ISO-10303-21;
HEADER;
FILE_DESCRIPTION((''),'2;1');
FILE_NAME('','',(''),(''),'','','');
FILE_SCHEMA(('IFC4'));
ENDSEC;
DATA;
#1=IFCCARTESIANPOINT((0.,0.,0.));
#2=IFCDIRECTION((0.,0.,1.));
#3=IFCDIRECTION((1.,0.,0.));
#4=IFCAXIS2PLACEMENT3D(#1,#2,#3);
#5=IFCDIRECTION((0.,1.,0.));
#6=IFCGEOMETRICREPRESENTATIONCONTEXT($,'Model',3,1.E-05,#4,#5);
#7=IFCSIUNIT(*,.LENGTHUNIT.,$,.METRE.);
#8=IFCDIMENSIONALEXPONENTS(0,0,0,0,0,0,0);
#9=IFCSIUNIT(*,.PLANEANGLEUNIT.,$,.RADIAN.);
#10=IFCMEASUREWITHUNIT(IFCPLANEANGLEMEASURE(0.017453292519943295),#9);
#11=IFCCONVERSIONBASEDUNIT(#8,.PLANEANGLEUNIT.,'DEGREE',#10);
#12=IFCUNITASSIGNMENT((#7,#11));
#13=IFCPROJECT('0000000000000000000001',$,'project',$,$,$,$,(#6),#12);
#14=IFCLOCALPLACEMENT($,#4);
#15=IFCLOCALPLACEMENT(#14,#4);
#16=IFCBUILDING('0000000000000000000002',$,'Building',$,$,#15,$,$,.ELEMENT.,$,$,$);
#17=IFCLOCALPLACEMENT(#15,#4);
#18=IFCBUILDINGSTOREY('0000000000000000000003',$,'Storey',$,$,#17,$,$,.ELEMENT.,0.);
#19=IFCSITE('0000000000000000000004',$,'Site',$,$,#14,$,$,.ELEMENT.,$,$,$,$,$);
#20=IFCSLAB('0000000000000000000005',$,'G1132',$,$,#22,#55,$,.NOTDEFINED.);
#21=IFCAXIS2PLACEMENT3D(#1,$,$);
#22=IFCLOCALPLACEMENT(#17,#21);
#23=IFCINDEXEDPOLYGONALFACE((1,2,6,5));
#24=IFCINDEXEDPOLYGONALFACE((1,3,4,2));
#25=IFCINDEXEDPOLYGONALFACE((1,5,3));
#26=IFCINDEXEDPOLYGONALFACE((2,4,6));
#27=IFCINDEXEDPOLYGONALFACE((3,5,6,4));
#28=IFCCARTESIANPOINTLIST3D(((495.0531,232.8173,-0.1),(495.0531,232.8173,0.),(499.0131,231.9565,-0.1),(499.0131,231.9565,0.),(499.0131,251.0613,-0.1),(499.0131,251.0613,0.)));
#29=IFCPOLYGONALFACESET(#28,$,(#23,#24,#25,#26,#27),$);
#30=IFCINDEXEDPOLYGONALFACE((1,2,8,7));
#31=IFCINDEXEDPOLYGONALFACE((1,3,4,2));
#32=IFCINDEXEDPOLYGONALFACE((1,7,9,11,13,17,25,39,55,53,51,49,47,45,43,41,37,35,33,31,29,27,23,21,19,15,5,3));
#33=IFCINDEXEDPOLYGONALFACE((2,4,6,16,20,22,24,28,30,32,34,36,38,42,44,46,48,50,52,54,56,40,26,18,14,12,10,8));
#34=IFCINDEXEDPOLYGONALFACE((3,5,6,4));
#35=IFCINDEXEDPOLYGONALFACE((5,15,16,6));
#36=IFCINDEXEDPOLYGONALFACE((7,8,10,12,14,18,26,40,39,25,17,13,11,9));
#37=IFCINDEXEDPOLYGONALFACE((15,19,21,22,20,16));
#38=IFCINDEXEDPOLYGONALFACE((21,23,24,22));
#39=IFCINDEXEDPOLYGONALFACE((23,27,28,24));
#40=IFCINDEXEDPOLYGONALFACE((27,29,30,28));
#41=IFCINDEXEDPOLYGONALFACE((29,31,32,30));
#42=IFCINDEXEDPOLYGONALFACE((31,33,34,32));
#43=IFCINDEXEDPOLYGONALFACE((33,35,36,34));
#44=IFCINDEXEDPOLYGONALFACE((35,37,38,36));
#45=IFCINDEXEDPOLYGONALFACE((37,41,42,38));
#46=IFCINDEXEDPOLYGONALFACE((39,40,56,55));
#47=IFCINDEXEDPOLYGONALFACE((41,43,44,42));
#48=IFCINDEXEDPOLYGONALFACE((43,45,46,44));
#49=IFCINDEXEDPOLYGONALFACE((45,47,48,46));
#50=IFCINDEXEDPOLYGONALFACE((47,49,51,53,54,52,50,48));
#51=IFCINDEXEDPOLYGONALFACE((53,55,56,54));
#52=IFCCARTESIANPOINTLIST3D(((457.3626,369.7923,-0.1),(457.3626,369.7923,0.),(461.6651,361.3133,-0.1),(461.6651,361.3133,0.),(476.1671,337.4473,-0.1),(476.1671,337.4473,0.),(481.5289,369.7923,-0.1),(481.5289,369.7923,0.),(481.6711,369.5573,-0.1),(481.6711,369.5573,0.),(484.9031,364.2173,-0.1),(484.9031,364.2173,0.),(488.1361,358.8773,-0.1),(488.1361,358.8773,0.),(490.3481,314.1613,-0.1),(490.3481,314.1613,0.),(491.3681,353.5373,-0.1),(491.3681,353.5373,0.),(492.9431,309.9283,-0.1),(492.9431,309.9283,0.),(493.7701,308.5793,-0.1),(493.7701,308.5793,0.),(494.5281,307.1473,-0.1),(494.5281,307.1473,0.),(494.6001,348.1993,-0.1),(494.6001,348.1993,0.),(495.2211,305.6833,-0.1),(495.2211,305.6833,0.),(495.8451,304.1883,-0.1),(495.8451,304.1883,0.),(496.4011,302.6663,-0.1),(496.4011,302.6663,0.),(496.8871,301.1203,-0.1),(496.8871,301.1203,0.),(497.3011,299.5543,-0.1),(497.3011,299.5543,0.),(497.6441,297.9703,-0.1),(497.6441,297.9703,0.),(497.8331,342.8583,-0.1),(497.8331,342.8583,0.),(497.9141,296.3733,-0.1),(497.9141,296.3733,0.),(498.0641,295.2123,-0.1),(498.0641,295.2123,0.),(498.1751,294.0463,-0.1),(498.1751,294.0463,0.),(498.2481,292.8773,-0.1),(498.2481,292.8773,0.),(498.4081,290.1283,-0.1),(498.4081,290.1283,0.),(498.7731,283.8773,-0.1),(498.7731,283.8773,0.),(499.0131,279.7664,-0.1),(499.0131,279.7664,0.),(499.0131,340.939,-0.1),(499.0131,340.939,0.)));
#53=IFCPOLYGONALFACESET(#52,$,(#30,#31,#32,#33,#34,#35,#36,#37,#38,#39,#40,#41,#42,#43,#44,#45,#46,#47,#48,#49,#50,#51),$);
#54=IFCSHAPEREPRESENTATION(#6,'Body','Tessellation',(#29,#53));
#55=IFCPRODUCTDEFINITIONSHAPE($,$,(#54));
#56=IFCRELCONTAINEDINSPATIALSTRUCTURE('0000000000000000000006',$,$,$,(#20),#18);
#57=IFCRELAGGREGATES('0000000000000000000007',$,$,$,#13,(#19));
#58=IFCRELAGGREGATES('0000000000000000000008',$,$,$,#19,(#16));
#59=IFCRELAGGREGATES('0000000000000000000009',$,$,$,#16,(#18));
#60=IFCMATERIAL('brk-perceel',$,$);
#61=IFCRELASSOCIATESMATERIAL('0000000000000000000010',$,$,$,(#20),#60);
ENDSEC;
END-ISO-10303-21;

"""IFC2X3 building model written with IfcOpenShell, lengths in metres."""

from ifc_helpers import new_model, entity, si_unit, converted_unit, direction, frame, origin_with_axes, place, context, project, spatial, polyline, outline, extrude, material, element, save


model = new_model("IFC2X3")

# Units and contexts
model_context = context("Model", 3, precision=1e-05, world=origin_with_axes(), true_north=direction((0.0, 1.0, 0.0)))
ifc_project = project(units=[si_unit("LENGTHUNIT", "METRE"), converted_unit("PLANEANGLEUNIT", "DEGREE", entity("IfcPlaneAngleMeasure", 0.017453292519943295), si_unit("PLANEANGLEUNIT", "RADIAN"), dimensions=[0, 0, 0, 0, 0, 0, 0])], contexts=[model_context])

# Site, building, storey
site_placement = place(None, origin_with_axes())
site = spatial("IfcSite", under=ifc_project, at=site_placement, Name="Site", CompositionType="ELEMENT")
building_placement = place(site_placement, origin_with_axes())
building = spatial("IfcBuilding", under=site, at=building_placement, Name="Building", CompositionType="ELEMENT")
storey_placement = place(building_placement, origin_with_axes())
storey = spatial("IfcBuildingStorey", under=building, at=storey_placement, Name="Storey", CompositionType="ELEMENT", Elevation=0.0)

# Slab
ifc_material = material(Name="brk-perceel")
slab_1_placement = place(storey_placement, frame((0.0, 0.0, -0.1), z_axis=(0.0, 0.0, 1.0), x_axis=(1.0, 0.0, 0.0)))
element("IfcSlab", 1, at=slab_1_placement, inside=storey, material=ifc_material, Name="G1132", PredefinedType="NOTDEFINED", context=model_context, shape_type="SweptSolid", body=[
    extrude(outline(polyline([(495.0531, 232.8173), (499.0131, 251.0613), (499.0131, 231.9565), (495.0531, 232.8173)])), origin_with_axes(), (0.0, 0.0, 1.0), 0.1),
    extrude(outline(polyline([(498.7731, 283.8773), (498.4081, 290.1283), (498.2481, 292.8773), (498.1751, 294.0463), (498.0641, 295.2123), (497.9141, 296.3733), (497.6441, 297.9703), (497.3011, 299.5543), (496.8871, 301.1203), (496.4011, 302.6663), (495.8451, 304.1883), (495.2211, 305.6833), (494.5281, 307.1473), (493.7701, 308.5793), (492.9431, 309.9283), (490.3481, 314.1613), (476.1671, 337.4473), (461.6651, 361.3133), (457.3626, 369.7923), (481.5289, 369.7923), (481.6711, 369.5573), (484.9031, 364.2173), (488.1361, 358.8773), (491.3681, 353.5373), (494.6001, 348.1993), (497.8331, 342.8583), (499.0131, 340.939), (499.0131, 279.7664), (498.7731, 283.8773)])), origin_with_axes(), (0.0, 0.0, 1.0), 0.1),
])

save(model, "model.ifc")
